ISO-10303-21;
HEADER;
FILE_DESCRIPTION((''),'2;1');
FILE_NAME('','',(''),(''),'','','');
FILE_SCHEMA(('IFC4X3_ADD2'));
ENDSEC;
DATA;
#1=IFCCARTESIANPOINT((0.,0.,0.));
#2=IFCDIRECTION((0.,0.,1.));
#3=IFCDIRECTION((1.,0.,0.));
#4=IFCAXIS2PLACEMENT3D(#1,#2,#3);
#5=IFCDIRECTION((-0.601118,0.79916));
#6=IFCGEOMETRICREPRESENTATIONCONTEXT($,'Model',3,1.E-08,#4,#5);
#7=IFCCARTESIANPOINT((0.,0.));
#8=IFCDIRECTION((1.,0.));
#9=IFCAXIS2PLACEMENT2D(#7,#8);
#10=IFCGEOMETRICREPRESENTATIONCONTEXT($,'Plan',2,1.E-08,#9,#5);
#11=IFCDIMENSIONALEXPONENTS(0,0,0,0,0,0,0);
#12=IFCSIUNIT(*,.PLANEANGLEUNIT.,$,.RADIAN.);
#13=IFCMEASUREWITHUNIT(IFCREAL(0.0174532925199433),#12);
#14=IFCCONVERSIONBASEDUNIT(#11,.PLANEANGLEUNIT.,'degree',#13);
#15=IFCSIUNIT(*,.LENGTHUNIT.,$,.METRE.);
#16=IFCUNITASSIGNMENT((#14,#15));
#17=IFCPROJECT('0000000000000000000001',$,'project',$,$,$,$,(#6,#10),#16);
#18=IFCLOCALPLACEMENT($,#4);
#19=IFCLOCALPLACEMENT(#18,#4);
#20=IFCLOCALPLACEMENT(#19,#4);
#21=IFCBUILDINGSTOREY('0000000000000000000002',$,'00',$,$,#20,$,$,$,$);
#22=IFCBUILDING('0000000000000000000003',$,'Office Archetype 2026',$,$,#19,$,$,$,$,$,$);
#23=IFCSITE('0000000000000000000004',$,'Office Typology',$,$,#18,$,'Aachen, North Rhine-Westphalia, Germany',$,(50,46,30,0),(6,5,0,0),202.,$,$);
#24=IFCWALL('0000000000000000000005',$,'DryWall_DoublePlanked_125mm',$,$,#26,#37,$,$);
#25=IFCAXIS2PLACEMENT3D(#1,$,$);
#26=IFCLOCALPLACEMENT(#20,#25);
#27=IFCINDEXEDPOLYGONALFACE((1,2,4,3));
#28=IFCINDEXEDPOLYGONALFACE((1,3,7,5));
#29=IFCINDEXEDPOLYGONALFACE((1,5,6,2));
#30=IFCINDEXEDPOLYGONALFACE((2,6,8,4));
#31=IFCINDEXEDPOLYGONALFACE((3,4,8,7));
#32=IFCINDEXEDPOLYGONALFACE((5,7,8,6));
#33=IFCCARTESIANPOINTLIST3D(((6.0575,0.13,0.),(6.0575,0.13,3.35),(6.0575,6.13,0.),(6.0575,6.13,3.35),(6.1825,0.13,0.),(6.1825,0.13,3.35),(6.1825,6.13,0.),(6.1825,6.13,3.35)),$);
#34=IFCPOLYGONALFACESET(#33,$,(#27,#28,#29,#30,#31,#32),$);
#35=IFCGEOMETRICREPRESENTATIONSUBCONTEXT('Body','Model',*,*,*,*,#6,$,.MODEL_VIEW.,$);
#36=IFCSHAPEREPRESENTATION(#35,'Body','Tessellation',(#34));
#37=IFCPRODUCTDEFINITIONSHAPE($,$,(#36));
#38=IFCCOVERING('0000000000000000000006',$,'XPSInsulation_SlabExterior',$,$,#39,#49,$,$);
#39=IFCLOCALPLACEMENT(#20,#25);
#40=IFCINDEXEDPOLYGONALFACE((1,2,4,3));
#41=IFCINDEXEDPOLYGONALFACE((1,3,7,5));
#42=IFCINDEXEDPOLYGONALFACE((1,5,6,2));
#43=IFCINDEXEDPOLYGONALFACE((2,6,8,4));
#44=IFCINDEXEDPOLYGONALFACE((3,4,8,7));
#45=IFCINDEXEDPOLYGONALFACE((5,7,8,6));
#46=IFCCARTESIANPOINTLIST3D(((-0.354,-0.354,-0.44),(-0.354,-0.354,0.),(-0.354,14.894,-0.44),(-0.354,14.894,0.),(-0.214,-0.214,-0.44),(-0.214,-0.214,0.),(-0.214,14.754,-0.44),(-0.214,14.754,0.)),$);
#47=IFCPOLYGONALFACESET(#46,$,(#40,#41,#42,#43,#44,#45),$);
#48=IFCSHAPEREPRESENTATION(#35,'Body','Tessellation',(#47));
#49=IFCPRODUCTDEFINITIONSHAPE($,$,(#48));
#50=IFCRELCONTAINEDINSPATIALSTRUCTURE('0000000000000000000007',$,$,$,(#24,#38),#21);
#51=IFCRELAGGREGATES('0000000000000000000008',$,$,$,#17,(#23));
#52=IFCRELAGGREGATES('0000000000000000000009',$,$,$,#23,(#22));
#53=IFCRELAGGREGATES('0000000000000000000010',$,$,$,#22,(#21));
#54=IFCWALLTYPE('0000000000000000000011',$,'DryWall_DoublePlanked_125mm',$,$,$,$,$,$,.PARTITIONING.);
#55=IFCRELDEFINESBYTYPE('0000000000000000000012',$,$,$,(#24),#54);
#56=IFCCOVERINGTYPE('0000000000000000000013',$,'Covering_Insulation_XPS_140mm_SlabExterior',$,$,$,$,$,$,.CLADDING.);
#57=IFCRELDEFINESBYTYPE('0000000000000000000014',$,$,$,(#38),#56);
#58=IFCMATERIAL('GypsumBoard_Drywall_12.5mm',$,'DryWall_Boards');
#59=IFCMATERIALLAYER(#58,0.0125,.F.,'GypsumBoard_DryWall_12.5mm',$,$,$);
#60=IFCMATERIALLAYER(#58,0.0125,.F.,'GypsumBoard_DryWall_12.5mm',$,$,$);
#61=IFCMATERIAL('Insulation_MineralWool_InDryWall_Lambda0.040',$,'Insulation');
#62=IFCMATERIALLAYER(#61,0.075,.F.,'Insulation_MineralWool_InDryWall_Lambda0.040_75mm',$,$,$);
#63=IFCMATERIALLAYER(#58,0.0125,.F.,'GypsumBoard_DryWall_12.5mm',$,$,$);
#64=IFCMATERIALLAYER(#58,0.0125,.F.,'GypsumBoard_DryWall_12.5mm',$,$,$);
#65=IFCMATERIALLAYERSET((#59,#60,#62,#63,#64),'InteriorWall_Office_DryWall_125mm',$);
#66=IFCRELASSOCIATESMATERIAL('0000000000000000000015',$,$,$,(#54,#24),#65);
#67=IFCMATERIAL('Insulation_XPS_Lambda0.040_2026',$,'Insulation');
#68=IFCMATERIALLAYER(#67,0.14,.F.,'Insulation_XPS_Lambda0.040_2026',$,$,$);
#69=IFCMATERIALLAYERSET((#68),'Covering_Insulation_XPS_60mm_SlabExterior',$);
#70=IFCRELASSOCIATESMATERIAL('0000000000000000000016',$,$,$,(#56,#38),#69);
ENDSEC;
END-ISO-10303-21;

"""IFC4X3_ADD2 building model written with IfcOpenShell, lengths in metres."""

from ifc_helpers import new_model, entity, si_unit, converted_unit, direction, frame, origin_with_axes, origin_2d_with_axis, place, context, subcontext, project, spatial, line, indexed_curve, outline, extrude, material, layer, layer_set, layer_usage, type_object, element, save


model = new_model("IFC4X3_ADD2")

# Units and contexts
model_context = context("Model", 3, precision=1e-08, world=origin_with_axes(), true_north=direction((-0.601118, 0.79916)))
plan_context = context("Plan", 2, precision=1e-08, world=origin_2d_with_axis(), true_north=direction((-0.601118, 0.79916)))
body_context = subcontext(model_context, "Body", "Model", "MODEL_VIEW")
ifc_project = project(units=[converted_unit("PLANEANGLEUNIT", "degree", entity("IfcReal", 0.0174532925199433), si_unit("PLANEANGLEUNIT", "RADIAN"), dimensions=[0, 0, 0, 0, 0, 0, 0]), si_unit("LENGTHUNIT", "METRE")], contexts=[model_context, plan_context])

# Site, building, storey
site_placement = place(None, origin_with_axes())
site = spatial("IfcSite", under=ifc_project, at=site_placement, Name="Office Typology", LongName="Aachen, North Rhine-Westphalia, Germany", RefLatitude=(50, 46, 30, 0), RefLongitude=(6, 5, 0, 0), RefElevation=202.0)
building_placement = place(site_placement, origin_with_axes())
building = spatial("IfcBuilding", under=site, at=building_placement, Name="Office Archetype 2026")
storey_placement = place(building_placement, origin_with_axes())
storey = spatial("IfcBuildingStorey", under=building, at=storey_placement, Name="00")

# Wall
ifc_material_1 = material(Name="GypsumBoard_Drywall_12.5mm", Category="DryWall_Boards")
ifc_layer_1 = layer(ifc_material_1, 0.0125, ventilated=False, Name="GypsumBoard_DryWall_12.5mm")
ifc_layer_2 = layer(ifc_material_1, 0.0125, ventilated=False, Name="GypsumBoard_DryWall_12.5mm")
ifc_material_2 = material(Name="Insulation_MineralWool_InDryWall_Lambda0.040", Category="Insulation")
ifc_layer_3 = layer(ifc_material_2, 0.075, ventilated=False, Name="Insulation_MineralWool_InDryWall_Lambda0.040_75mm")
ifc_layer_4 = layer(ifc_material_1, 0.0125, ventilated=False, Name="GypsumBoard_DryWall_12.5mm")
ifc_layer_5 = layer(ifc_material_1, 0.0125, ventilated=False, Name="GypsumBoard_DryWall_12.5mm")
ifc_layer_set_1 = layer_set([ifc_layer_1, ifc_layer_2, ifc_layer_3, ifc_layer_4, ifc_layer_5], Name="InteriorWall_Office_DryWall_125mm")
ifc_layer_usage_1 = layer_usage(ifc_layer_set_1, "AXIS2", "POSITIVE", 0.0)
wall_type_1 = type_object("IfcWallType", Name="DryWall_DoublePlanked_125mm", PredefinedType="PARTITIONING", material=ifc_layer_set_1)
wall_1_placement = place(storey_placement, frame((6.0575, 6.13, 0.0), z_axis=(0.0, 0.0, 1.0), x_axis=(0.0, -1.0, 0.0)))
element("IfcWall", 1, at=wall_1_placement, inside=storey, type_object=wall_type_1, material=ifc_layer_usage_1, Name="DryWall_DoublePlanked_125mm", context=body_context, shape_type="SweptSolid", body=[
    extrude(outline(indexed_curve([(0.0, 0.0), (0.0, 0.125), (6.0, 0.125), (6.0, 0.0)], segments=[line(1, 2, 3, 4, 1)])), origin_with_axes(), (0.0, 0.0, 1.0), 3.35),
])

# Covering
ifc_material_3 = material(Name="Insulation_XPS_Lambda0.040_2026", Category="Insulation")
ifc_layer_6 = layer(ifc_material_3, 0.14, ventilated=False, Name="Insulation_XPS_Lambda0.040_2026")
ifc_layer_set_2 = layer_set([ifc_layer_6], Name="Covering_Insulation_XPS_60mm_SlabExterior")
ifc_layer_usage_2 = layer_usage(ifc_layer_set_2, "AXIS2", "POSITIVE", 0.0)
covering_type = type_object("IfcCoveringType", Name="Covering_Insulation_XPS_140mm_SlabExterior", PredefinedType="CLADDING", material=ifc_layer_set_2)
covering_placement = place(storey_placement, frame((-0.354, 14.894, -0.44), z_axis=(0.0, 0.0, 1.0), x_axis=(0.0, -1.0, 0.0)))
element("IfcCovering", 2, at=covering_placement, inside=storey, type_object=covering_type, material=ifc_layer_usage_2, Name="XPSInsulation_SlabExterior", context=body_context, shape_type="SweptSolid", body=[
    extrude(outline(indexed_curve([(0.0, 0.0), (0.14, 0.14), (15.108, 0.14), (15.248, 0.0)], segments=[line(1, 2, 3, 4, 1)])), origin_with_axes(), (0.0, 0.0, 1.0), 0.44),
])

save(model, "model.ifc")
